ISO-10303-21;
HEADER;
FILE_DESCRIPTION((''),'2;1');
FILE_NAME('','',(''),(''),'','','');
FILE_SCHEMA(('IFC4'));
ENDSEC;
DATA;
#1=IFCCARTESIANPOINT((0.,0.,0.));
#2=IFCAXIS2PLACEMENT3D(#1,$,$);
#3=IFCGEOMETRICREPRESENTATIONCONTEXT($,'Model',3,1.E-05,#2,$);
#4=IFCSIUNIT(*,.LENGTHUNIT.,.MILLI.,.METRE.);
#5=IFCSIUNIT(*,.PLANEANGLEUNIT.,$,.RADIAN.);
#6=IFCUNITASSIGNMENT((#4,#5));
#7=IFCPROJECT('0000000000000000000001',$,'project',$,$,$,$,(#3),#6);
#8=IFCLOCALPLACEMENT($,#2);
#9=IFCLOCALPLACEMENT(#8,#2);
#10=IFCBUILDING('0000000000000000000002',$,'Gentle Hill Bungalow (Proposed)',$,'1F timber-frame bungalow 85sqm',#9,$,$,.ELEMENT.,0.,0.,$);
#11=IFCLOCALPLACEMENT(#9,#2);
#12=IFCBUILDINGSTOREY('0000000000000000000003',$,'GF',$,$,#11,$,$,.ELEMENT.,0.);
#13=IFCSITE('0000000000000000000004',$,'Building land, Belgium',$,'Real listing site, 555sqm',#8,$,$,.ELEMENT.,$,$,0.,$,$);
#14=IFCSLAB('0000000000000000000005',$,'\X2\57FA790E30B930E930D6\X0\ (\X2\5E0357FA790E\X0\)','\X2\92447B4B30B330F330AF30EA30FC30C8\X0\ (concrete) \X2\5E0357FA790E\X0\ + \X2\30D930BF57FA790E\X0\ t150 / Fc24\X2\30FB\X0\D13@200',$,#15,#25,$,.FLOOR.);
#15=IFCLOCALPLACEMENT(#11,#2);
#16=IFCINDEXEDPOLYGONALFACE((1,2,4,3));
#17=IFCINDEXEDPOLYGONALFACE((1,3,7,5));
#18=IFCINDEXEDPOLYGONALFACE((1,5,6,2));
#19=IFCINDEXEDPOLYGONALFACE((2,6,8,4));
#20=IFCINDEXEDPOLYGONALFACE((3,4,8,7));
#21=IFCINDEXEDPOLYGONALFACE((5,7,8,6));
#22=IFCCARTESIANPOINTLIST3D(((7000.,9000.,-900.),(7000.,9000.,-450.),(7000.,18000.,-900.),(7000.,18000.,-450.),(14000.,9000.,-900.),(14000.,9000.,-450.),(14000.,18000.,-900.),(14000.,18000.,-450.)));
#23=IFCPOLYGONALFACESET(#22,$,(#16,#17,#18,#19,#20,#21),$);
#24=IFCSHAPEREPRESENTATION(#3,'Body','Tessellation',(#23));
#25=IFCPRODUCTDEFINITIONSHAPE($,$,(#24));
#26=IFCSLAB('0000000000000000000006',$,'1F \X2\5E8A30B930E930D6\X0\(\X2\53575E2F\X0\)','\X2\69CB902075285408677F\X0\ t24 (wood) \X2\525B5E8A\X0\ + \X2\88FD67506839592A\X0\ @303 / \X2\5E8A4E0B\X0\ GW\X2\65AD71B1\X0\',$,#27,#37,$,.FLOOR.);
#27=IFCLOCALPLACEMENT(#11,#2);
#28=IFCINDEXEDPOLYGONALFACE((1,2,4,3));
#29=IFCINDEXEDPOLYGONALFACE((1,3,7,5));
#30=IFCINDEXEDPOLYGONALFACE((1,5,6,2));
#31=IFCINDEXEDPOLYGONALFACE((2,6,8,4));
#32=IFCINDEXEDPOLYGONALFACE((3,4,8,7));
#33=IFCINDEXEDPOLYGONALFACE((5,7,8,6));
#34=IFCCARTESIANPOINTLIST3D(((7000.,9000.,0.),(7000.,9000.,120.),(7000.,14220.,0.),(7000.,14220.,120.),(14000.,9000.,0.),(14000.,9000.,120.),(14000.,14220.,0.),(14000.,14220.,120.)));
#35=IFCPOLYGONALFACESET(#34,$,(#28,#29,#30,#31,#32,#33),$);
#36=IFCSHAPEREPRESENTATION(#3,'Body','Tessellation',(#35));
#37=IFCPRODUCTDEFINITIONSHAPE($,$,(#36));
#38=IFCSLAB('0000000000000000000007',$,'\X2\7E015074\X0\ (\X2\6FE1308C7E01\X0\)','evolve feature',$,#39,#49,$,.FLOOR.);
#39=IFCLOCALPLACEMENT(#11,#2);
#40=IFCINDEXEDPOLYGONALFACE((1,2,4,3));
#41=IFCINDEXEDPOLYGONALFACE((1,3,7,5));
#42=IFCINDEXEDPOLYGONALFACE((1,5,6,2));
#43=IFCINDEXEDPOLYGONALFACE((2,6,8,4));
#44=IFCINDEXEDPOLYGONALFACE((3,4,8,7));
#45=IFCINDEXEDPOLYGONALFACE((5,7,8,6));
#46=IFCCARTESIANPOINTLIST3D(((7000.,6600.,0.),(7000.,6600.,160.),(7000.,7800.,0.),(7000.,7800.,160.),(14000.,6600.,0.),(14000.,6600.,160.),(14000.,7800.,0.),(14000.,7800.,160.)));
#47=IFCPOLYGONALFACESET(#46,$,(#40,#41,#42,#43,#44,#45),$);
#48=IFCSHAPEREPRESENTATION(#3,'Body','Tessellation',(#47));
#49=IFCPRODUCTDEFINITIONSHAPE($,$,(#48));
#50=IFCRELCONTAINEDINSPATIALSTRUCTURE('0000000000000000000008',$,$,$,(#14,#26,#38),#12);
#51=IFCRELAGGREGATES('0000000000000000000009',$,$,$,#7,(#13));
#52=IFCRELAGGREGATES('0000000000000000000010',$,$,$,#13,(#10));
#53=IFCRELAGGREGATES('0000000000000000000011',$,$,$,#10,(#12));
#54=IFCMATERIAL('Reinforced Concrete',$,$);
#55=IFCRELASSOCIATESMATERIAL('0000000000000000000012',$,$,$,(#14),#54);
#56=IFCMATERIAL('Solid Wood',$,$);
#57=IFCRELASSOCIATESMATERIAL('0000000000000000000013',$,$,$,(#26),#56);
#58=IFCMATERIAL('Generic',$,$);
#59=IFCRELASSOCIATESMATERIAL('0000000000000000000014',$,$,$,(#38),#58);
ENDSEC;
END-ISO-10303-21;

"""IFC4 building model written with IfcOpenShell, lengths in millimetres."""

from ifc_helpers import new_model, si_unit, frame, frame_2d, origin, place, context, project, spatial, rectangle, extrude, material, element, save


model = new_model("IFC4")

# Units and contexts
model_context = context("Model", 3, precision=1e-05, world=origin())
ifc_project = project(units=[si_unit("LENGTHUNIT", "METRE", prefix="MILLI"), si_unit("PLANEANGLEUNIT", "RADIAN")], contexts=[model_context])

# Site, building, storey
site_placement = place(None, origin())
site = spatial("IfcSite", under=ifc_project, at=site_placement, Name="Building land, Belgium", ObjectType="Real listing site, 555sqm", CompositionType="ELEMENT", RefElevation=0.0)
building_placement = place(site_placement, origin())
building = spatial("IfcBuilding", under=site, at=building_placement, Name="Gentle Hill Bungalow (Proposed)", ObjectType="1F timber-frame bungalow 85sqm", CompositionType="ELEMENT", ElevationOfRefHeight=0.0, ElevationOfTerrain=0.0)
storey_placement = place(building_placement, origin())
storey = spatial("IfcBuildingStorey", under=building, at=storey_placement, Name="GF", CompositionType="ELEMENT", Elevation=0.0)

# Slabs
ifc_material_1 = material(Name="Reinforced Concrete")
slab_1_placement = place(storey_placement, frame((3500.0, 4500.0, -450.0)))
element("IfcSlab", 1, at=slab_1_placement, inside=storey, material=ifc_material_1, Name="基礎スラブ (布基礎)", Description="鉄筋コンクリート (concrete) 布基礎 + ベタ基礎 t150 / Fc24・D13@200", PredefinedType="FLOOR", context=model_context, shape_type="SweptSolid", body=[
    extrude(rectangle(XDim=7000.0, YDim=9000.0, at=frame_2d((3500.0, 4500.0))), frame((3500.0, 4500.0, -450.0)), (0.0, 0.0, 1.0), 450.0),
])
ifc_material_2 = material(Name="Solid Wood")
slab_2_placement = place(storey_placement, frame((3500.0, 4500.0, 0.0)))
element("IfcSlab", 2, at=slab_2_placement, inside=storey, material=ifc_material_2, Name="1F 床スラブ(南帯)", Description="構造用合板 t24 (wood) 剛床 + 製材根太 @303 / 床下 GW断熱", PredefinedType="FLOOR", context=model_context, shape_type="SweptSolid", body=[
    extrude(rectangle(XDim=7000.0, YDim=5220.0, at=frame_2d((3500.0, 2610.0))), frame((3500.0, 4500.0, 0.0)), (0.0, 0.0, 1.0), 120.0),
])
ifc_material_3 = material(Name="Generic")
slab_3_placement = place(storey_placement, frame((3500.0, 3300.0, 0.0)))
element("IfcSlab", 3, at=slab_3_placement, inside=storey, material=ifc_material_3, Name="縁側 (濡れ縁)", Description="evolve feature", PredefinedType="FLOOR", context=model_context, shape_type="SweptSolid", body=[
    extrude(rectangle(XDim=7000.0, YDim=1200.0, at=frame_2d((3500.0, 600.0))), frame((3500.0, 3300.0, 0.0)), (0.0, 0.0, 1.0), 160.0),
])

save(model, "model.ifc")
